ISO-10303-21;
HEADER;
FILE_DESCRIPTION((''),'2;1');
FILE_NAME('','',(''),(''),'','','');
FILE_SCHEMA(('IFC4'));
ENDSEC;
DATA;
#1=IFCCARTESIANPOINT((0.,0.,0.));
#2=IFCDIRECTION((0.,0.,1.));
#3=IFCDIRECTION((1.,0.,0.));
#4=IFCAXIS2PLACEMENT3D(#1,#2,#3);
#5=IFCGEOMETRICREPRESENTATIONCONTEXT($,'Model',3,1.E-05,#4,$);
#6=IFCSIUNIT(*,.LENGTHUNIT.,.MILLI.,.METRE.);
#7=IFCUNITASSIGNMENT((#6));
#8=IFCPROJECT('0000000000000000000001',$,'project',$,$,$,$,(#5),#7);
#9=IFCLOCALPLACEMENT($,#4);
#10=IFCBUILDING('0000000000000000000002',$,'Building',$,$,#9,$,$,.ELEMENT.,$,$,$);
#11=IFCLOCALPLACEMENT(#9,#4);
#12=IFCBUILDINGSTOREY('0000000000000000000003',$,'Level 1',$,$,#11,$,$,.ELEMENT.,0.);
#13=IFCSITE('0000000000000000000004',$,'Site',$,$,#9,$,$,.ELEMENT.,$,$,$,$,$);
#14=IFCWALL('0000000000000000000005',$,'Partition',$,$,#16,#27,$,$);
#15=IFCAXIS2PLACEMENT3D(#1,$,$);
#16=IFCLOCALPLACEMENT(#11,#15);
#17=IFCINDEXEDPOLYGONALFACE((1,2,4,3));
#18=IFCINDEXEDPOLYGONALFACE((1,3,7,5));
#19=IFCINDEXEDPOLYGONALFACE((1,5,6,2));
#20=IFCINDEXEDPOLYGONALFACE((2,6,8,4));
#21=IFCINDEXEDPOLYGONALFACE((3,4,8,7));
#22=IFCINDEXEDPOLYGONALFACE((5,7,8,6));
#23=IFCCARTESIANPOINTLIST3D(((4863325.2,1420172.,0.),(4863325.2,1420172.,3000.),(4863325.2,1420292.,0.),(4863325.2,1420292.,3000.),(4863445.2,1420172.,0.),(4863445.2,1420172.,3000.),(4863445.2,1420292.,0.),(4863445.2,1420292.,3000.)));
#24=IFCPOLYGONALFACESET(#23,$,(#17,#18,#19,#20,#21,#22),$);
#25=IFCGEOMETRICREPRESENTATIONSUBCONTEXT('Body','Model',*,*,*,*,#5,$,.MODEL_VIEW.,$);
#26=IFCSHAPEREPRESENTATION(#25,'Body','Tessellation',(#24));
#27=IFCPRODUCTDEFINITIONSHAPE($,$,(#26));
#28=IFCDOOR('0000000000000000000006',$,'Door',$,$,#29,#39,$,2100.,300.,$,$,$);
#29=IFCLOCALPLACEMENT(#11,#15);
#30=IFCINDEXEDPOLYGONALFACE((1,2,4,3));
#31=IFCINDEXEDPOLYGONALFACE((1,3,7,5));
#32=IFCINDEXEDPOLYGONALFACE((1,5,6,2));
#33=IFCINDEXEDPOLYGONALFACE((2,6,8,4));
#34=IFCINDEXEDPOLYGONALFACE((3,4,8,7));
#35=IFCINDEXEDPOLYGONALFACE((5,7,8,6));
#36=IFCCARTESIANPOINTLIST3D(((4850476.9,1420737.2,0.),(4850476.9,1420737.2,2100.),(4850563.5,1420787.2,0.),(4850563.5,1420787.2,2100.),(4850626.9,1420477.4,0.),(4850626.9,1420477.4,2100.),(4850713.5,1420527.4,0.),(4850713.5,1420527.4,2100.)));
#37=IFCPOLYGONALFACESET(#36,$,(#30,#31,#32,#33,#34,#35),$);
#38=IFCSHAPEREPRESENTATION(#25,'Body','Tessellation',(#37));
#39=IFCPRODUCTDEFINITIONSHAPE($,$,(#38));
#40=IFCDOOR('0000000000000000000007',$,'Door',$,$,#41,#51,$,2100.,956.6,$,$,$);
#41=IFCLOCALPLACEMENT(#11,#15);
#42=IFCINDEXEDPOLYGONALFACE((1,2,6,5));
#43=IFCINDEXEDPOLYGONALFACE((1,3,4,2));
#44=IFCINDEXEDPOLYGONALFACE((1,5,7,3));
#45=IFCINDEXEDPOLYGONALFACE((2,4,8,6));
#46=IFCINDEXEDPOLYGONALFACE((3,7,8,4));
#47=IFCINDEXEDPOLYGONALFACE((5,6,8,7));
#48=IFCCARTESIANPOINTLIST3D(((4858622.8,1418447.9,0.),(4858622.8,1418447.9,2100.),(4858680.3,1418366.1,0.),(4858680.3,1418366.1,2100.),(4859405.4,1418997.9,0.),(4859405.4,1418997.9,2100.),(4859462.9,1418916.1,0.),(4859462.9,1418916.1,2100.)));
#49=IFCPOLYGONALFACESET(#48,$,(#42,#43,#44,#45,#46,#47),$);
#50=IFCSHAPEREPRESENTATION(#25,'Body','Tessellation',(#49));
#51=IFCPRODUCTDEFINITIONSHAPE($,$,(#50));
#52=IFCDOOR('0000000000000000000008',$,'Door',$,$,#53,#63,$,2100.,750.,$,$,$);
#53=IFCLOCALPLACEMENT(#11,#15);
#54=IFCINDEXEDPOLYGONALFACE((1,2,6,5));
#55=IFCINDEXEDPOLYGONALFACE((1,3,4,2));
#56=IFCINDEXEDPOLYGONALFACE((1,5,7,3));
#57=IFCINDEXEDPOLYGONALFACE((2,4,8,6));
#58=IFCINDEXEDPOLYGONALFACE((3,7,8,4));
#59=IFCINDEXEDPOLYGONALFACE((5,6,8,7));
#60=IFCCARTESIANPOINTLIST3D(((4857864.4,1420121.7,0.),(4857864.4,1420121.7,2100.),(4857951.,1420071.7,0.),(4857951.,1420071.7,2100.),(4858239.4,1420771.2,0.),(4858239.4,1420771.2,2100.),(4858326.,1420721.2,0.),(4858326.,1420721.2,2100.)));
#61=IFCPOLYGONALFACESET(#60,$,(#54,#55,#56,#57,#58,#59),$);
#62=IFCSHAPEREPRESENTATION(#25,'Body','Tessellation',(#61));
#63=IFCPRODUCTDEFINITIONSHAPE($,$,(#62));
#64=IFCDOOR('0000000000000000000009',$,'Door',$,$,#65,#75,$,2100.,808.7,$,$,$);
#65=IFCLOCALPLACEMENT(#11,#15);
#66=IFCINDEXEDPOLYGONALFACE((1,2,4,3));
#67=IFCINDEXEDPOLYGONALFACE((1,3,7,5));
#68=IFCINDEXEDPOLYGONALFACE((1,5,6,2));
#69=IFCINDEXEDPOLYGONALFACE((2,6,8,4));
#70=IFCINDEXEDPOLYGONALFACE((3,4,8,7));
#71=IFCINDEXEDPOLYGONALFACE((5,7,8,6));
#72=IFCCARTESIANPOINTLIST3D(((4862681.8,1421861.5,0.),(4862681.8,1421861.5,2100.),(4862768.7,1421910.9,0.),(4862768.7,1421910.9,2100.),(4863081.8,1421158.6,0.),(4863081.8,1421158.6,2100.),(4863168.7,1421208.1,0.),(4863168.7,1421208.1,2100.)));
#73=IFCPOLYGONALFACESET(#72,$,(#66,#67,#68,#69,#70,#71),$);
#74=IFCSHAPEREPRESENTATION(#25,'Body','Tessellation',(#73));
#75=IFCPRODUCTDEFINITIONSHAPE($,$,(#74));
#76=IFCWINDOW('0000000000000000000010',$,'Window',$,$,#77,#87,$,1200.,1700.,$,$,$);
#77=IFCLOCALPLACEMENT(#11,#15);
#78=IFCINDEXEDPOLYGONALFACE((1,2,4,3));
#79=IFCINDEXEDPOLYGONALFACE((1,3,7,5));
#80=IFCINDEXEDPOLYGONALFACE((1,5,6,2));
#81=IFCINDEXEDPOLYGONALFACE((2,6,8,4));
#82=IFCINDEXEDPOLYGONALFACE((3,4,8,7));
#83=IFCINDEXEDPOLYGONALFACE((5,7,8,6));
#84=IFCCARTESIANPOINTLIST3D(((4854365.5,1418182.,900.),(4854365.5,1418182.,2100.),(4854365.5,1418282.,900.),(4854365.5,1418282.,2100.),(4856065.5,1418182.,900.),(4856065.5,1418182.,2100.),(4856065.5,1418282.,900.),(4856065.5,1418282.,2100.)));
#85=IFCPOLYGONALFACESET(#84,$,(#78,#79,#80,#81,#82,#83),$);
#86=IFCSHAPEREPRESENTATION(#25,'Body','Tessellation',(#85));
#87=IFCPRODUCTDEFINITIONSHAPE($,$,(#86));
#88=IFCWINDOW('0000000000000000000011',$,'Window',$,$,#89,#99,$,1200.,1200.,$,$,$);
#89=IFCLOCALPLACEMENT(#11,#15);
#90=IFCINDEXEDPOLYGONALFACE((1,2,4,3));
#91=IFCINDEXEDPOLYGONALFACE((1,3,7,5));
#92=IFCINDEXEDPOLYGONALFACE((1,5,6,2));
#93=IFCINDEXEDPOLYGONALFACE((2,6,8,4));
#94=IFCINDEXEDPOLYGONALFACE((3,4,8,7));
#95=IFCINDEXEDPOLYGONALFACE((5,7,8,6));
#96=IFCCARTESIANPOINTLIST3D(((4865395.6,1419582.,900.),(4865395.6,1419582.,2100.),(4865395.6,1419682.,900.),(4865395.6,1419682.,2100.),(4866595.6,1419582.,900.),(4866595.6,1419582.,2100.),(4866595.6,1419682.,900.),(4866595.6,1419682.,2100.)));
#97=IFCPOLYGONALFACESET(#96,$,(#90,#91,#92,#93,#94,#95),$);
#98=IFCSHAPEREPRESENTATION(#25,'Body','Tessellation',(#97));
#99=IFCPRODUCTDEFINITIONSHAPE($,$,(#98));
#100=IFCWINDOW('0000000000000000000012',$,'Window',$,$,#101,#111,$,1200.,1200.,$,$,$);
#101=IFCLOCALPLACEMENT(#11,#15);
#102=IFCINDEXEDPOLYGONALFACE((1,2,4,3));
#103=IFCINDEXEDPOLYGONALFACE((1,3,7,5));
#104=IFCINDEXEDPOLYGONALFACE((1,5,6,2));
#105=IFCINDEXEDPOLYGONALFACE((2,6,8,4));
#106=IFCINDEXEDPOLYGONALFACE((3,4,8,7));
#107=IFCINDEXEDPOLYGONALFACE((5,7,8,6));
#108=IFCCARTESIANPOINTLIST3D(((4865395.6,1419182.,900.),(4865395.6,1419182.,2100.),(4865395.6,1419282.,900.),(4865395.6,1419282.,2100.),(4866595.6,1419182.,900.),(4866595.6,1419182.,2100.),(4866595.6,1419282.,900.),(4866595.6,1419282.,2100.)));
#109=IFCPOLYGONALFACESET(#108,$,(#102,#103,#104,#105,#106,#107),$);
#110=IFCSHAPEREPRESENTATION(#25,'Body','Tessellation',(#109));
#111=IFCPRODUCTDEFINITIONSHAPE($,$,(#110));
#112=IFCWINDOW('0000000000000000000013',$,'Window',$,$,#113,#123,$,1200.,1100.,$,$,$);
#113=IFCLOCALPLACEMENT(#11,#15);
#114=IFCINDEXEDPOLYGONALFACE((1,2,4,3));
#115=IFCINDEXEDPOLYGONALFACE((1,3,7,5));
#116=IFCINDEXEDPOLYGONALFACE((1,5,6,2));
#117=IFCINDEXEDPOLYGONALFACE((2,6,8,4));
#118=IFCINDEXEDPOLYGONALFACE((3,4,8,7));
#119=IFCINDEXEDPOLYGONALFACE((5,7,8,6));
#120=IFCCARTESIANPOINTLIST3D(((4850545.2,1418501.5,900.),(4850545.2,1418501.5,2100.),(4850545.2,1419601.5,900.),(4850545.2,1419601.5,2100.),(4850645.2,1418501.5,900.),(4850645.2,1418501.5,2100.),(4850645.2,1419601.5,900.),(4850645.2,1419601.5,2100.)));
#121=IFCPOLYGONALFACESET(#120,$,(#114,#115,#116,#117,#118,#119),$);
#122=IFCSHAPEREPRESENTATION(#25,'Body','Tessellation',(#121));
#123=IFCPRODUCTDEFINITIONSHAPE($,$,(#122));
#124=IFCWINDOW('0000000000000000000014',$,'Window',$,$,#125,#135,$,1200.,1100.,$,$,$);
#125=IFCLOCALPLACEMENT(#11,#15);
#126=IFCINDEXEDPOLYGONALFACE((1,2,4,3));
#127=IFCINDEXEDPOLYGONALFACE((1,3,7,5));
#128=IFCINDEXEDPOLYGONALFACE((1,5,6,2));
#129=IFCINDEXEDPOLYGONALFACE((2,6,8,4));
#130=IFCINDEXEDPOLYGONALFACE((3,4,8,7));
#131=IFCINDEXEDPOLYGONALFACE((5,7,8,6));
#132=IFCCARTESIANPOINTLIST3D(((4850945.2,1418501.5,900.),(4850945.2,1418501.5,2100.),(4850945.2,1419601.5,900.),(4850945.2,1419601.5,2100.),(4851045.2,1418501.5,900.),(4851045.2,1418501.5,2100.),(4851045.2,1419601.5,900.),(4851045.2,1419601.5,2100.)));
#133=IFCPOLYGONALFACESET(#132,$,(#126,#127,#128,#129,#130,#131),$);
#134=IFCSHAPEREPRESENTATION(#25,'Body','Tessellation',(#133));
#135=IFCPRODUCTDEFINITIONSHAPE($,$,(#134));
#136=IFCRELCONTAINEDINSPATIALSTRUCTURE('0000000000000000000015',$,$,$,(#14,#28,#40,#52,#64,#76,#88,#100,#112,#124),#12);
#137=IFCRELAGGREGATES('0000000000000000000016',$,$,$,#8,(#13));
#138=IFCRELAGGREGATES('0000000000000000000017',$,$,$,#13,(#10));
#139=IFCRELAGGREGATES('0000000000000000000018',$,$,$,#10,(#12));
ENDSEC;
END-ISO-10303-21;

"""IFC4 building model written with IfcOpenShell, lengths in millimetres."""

from ifc_helpers import new_model, si_unit, frame, frame_2d, origin_with_axes, place, context, subcontext, project, spatial, rectangle, extrude, element, save


model = new_model("IFC4")

# Units and contexts
model_context = context("Model", 3, precision=1e-05, world=origin_with_axes())
body_context = subcontext(model_context, "Body", "Model", "MODEL_VIEW")
ifc_project = project(units=[si_unit("LENGTHUNIT", "METRE", prefix="MILLI")], contexts=[model_context])

# Site, building, storey
placement = place(None, origin_with_axes())
site = spatial("IfcSite", under=ifc_project, at=placement, Name="Site", CompositionType="ELEMENT")
building = spatial("IfcBuilding", under=site, at=placement, Name="Building", CompositionType="ELEMENT")
storey_placement = place(placement, origin_with_axes())
storey = spatial("IfcBuildingStorey", under=building, at=storey_placement, Name="Level 1", CompositionType="ELEMENT", Elevation=0.0)

# Wall
wall_1_placement = place(placement, frame((4863325.2, 1420232.0, 0.0), z_axis=(0.0, 0.0, 1.0), x_axis=(1.0, 0.0, 0.0)))
element("IfcWall", 1, at=wall_1_placement, inside=storey, Name="Partition", context=body_context, shape_type="SweptSolid", body=[
    extrude(rectangle(XDim=120.0, YDim=120.0, at=frame_2d((60.0, 0.0), x_axis=(1.0, 0.0))), origin_with_axes(), (0.0, 0.0, 1.0), 3000.0),
])

# Doors
door_1_placement = place(placement, frame((4850520.2, 1420762.2, 0.0), z_axis=(0.0, 0.0, 1.0), x_axis=(0.5, -0.866025, 0.0)))
element("IfcDoor", 2, at=door_1_placement, inside=storey, Name="Door", OverallHeight=2100.0, OverallWidth=300.0, context=body_context, shape_type="SweptSolid", body=[
    extrude(rectangle(XDim=300.0, YDim=100.0, at=frame_2d((150.0, 0.0), x_axis=(1.0, 0.0))), origin_with_axes(), (0.0, 0.0, 1.0), 2100.0),
])
door_2_placement = place(placement, frame((4859434.1, 1418957.0, 0.0), z_axis=(0.0, 0.0, 1.0), x_axis=(-0.818169, -0.574977, 0.0)))
element("IfcDoor", 3, at=door_2_placement, inside=storey, Name="Door", OverallHeight=2100.0, OverallWidth=956.6, context=body_context, shape_type="SweptSolid", body=[
    extrude(rectangle(XDim=956.6, YDim=100.0, at=frame_2d((478.3, 0.0), x_axis=(1.0, 0.0))), origin_with_axes(), (0.0, 0.0, 1.0), 2100.0),
])
door_3_placement = place(placement, frame((4858282.7, 1420746.2, 0.0), z_axis=(0.0, 0.0, 1.0), x_axis=(-0.5, -0.866025, 0.0)))
element("IfcDoor", 4, at=door_3_placement, inside=storey, Name="Door", OverallHeight=2100.0, OverallWidth=750.0, context=body_context, shape_type="SweptSolid", body=[
    extrude(rectangle(XDim=750.0, YDim=100.0, at=frame_2d((375.0, 0.0), x_axis=(1.0, 0.0))), origin_with_axes(), (0.0, 0.0, 1.0), 2100.0),
])
door_4_placement = place(placement, frame((4863125.2, 1421183.4, 0.0), z_axis=(0.0, 0.0, 1.0), x_axis=(-0.494636, 0.8691, 0.0)))
element("IfcDoor", 5, at=door_4_placement, inside=storey, Name="Door", OverallHeight=2100.0, OverallWidth=808.7, context=body_context, shape_type="SweptSolid", body=[
    extrude(rectangle(XDim=808.7, YDim=100.0, at=frame_2d((404.3, 0.0), x_axis=(1.0, 0.0))), origin_with_axes(), (0.0, 0.0, 1.0), 2100.0),
])

# Windows
window_placement = place(placement, frame((4854365.5, 1418232.0, 900.0), z_axis=(0.0, 0.0, 1.0), x_axis=(1.0, 0.0, 0.0)))
element("IfcWindow", 6, at=window_placement, inside=storey, Name="Window", OverallHeight=1200.0, OverallWidth=1700.0, context=body_context, shape_type="SweptSolid", body=[
    extrude(rectangle(XDim=1700.0, YDim=100.0, at=frame_2d((850.0, 0.0), x_axis=(1.0, 0.0))), origin_with_axes(), (0.0, 0.0, 1.0), 1200.0),
])
for number, where, z_axis, x_axis, name in (
    (7, (4865395.6, 1419632.0, 900.0), (0.0, 0.0, 1.0), (1.0, 0.0, 0.0), "Window"),
    (8, (4865395.6, 1419232.0, 900.0), (0.0, 0.0, 1.0), (1.0, 0.0, 0.0), "Window"),
):
    element("IfcWindow", number, at=place(placement, frame(where, z_axis=z_axis, x_axis=x_axis)), inside=storey, Name=name, OverallHeight=1200.0, OverallWidth=1200.0, context=body_context, shape_type="SweptSolid", body=[
        extrude(rectangle(XDim=1200.0, YDim=100.0, at=frame_2d((600.0, 0.0), x_axis=(1.0, 0.0))), origin_with_axes(), (0.0, 0.0, 1.0), 1200.0),
    ])
for number, where, z_axis, x_axis, name in (
    (9, (4850595.2, 1419601.5, 900.0), (0.0, 0.0, 1.0), (0.0, -1.0, 0.0), "Window"),
    (10, (4850995.2, 1419601.5, 900.0), (0.0, 0.0, 1.0), (0.0, -1.0, 0.0), "Window"),
):
    element("IfcWindow", number, at=place(placement, frame(where, z_axis=z_axis, x_axis=x_axis)), inside=storey, Name=name, OverallHeight=1200.0, OverallWidth=1100.0, context=body_context, shape_type="SweptSolid", body=[
        extrude(rectangle(XDim=1100.0, YDim=100.0, at=frame_2d((550.0, 0.0), x_axis=(1.0, 0.0))), origin_with_axes(), (0.0, 0.0, 1.0), 1200.0),
    ])

save(model, "model.ifc")
